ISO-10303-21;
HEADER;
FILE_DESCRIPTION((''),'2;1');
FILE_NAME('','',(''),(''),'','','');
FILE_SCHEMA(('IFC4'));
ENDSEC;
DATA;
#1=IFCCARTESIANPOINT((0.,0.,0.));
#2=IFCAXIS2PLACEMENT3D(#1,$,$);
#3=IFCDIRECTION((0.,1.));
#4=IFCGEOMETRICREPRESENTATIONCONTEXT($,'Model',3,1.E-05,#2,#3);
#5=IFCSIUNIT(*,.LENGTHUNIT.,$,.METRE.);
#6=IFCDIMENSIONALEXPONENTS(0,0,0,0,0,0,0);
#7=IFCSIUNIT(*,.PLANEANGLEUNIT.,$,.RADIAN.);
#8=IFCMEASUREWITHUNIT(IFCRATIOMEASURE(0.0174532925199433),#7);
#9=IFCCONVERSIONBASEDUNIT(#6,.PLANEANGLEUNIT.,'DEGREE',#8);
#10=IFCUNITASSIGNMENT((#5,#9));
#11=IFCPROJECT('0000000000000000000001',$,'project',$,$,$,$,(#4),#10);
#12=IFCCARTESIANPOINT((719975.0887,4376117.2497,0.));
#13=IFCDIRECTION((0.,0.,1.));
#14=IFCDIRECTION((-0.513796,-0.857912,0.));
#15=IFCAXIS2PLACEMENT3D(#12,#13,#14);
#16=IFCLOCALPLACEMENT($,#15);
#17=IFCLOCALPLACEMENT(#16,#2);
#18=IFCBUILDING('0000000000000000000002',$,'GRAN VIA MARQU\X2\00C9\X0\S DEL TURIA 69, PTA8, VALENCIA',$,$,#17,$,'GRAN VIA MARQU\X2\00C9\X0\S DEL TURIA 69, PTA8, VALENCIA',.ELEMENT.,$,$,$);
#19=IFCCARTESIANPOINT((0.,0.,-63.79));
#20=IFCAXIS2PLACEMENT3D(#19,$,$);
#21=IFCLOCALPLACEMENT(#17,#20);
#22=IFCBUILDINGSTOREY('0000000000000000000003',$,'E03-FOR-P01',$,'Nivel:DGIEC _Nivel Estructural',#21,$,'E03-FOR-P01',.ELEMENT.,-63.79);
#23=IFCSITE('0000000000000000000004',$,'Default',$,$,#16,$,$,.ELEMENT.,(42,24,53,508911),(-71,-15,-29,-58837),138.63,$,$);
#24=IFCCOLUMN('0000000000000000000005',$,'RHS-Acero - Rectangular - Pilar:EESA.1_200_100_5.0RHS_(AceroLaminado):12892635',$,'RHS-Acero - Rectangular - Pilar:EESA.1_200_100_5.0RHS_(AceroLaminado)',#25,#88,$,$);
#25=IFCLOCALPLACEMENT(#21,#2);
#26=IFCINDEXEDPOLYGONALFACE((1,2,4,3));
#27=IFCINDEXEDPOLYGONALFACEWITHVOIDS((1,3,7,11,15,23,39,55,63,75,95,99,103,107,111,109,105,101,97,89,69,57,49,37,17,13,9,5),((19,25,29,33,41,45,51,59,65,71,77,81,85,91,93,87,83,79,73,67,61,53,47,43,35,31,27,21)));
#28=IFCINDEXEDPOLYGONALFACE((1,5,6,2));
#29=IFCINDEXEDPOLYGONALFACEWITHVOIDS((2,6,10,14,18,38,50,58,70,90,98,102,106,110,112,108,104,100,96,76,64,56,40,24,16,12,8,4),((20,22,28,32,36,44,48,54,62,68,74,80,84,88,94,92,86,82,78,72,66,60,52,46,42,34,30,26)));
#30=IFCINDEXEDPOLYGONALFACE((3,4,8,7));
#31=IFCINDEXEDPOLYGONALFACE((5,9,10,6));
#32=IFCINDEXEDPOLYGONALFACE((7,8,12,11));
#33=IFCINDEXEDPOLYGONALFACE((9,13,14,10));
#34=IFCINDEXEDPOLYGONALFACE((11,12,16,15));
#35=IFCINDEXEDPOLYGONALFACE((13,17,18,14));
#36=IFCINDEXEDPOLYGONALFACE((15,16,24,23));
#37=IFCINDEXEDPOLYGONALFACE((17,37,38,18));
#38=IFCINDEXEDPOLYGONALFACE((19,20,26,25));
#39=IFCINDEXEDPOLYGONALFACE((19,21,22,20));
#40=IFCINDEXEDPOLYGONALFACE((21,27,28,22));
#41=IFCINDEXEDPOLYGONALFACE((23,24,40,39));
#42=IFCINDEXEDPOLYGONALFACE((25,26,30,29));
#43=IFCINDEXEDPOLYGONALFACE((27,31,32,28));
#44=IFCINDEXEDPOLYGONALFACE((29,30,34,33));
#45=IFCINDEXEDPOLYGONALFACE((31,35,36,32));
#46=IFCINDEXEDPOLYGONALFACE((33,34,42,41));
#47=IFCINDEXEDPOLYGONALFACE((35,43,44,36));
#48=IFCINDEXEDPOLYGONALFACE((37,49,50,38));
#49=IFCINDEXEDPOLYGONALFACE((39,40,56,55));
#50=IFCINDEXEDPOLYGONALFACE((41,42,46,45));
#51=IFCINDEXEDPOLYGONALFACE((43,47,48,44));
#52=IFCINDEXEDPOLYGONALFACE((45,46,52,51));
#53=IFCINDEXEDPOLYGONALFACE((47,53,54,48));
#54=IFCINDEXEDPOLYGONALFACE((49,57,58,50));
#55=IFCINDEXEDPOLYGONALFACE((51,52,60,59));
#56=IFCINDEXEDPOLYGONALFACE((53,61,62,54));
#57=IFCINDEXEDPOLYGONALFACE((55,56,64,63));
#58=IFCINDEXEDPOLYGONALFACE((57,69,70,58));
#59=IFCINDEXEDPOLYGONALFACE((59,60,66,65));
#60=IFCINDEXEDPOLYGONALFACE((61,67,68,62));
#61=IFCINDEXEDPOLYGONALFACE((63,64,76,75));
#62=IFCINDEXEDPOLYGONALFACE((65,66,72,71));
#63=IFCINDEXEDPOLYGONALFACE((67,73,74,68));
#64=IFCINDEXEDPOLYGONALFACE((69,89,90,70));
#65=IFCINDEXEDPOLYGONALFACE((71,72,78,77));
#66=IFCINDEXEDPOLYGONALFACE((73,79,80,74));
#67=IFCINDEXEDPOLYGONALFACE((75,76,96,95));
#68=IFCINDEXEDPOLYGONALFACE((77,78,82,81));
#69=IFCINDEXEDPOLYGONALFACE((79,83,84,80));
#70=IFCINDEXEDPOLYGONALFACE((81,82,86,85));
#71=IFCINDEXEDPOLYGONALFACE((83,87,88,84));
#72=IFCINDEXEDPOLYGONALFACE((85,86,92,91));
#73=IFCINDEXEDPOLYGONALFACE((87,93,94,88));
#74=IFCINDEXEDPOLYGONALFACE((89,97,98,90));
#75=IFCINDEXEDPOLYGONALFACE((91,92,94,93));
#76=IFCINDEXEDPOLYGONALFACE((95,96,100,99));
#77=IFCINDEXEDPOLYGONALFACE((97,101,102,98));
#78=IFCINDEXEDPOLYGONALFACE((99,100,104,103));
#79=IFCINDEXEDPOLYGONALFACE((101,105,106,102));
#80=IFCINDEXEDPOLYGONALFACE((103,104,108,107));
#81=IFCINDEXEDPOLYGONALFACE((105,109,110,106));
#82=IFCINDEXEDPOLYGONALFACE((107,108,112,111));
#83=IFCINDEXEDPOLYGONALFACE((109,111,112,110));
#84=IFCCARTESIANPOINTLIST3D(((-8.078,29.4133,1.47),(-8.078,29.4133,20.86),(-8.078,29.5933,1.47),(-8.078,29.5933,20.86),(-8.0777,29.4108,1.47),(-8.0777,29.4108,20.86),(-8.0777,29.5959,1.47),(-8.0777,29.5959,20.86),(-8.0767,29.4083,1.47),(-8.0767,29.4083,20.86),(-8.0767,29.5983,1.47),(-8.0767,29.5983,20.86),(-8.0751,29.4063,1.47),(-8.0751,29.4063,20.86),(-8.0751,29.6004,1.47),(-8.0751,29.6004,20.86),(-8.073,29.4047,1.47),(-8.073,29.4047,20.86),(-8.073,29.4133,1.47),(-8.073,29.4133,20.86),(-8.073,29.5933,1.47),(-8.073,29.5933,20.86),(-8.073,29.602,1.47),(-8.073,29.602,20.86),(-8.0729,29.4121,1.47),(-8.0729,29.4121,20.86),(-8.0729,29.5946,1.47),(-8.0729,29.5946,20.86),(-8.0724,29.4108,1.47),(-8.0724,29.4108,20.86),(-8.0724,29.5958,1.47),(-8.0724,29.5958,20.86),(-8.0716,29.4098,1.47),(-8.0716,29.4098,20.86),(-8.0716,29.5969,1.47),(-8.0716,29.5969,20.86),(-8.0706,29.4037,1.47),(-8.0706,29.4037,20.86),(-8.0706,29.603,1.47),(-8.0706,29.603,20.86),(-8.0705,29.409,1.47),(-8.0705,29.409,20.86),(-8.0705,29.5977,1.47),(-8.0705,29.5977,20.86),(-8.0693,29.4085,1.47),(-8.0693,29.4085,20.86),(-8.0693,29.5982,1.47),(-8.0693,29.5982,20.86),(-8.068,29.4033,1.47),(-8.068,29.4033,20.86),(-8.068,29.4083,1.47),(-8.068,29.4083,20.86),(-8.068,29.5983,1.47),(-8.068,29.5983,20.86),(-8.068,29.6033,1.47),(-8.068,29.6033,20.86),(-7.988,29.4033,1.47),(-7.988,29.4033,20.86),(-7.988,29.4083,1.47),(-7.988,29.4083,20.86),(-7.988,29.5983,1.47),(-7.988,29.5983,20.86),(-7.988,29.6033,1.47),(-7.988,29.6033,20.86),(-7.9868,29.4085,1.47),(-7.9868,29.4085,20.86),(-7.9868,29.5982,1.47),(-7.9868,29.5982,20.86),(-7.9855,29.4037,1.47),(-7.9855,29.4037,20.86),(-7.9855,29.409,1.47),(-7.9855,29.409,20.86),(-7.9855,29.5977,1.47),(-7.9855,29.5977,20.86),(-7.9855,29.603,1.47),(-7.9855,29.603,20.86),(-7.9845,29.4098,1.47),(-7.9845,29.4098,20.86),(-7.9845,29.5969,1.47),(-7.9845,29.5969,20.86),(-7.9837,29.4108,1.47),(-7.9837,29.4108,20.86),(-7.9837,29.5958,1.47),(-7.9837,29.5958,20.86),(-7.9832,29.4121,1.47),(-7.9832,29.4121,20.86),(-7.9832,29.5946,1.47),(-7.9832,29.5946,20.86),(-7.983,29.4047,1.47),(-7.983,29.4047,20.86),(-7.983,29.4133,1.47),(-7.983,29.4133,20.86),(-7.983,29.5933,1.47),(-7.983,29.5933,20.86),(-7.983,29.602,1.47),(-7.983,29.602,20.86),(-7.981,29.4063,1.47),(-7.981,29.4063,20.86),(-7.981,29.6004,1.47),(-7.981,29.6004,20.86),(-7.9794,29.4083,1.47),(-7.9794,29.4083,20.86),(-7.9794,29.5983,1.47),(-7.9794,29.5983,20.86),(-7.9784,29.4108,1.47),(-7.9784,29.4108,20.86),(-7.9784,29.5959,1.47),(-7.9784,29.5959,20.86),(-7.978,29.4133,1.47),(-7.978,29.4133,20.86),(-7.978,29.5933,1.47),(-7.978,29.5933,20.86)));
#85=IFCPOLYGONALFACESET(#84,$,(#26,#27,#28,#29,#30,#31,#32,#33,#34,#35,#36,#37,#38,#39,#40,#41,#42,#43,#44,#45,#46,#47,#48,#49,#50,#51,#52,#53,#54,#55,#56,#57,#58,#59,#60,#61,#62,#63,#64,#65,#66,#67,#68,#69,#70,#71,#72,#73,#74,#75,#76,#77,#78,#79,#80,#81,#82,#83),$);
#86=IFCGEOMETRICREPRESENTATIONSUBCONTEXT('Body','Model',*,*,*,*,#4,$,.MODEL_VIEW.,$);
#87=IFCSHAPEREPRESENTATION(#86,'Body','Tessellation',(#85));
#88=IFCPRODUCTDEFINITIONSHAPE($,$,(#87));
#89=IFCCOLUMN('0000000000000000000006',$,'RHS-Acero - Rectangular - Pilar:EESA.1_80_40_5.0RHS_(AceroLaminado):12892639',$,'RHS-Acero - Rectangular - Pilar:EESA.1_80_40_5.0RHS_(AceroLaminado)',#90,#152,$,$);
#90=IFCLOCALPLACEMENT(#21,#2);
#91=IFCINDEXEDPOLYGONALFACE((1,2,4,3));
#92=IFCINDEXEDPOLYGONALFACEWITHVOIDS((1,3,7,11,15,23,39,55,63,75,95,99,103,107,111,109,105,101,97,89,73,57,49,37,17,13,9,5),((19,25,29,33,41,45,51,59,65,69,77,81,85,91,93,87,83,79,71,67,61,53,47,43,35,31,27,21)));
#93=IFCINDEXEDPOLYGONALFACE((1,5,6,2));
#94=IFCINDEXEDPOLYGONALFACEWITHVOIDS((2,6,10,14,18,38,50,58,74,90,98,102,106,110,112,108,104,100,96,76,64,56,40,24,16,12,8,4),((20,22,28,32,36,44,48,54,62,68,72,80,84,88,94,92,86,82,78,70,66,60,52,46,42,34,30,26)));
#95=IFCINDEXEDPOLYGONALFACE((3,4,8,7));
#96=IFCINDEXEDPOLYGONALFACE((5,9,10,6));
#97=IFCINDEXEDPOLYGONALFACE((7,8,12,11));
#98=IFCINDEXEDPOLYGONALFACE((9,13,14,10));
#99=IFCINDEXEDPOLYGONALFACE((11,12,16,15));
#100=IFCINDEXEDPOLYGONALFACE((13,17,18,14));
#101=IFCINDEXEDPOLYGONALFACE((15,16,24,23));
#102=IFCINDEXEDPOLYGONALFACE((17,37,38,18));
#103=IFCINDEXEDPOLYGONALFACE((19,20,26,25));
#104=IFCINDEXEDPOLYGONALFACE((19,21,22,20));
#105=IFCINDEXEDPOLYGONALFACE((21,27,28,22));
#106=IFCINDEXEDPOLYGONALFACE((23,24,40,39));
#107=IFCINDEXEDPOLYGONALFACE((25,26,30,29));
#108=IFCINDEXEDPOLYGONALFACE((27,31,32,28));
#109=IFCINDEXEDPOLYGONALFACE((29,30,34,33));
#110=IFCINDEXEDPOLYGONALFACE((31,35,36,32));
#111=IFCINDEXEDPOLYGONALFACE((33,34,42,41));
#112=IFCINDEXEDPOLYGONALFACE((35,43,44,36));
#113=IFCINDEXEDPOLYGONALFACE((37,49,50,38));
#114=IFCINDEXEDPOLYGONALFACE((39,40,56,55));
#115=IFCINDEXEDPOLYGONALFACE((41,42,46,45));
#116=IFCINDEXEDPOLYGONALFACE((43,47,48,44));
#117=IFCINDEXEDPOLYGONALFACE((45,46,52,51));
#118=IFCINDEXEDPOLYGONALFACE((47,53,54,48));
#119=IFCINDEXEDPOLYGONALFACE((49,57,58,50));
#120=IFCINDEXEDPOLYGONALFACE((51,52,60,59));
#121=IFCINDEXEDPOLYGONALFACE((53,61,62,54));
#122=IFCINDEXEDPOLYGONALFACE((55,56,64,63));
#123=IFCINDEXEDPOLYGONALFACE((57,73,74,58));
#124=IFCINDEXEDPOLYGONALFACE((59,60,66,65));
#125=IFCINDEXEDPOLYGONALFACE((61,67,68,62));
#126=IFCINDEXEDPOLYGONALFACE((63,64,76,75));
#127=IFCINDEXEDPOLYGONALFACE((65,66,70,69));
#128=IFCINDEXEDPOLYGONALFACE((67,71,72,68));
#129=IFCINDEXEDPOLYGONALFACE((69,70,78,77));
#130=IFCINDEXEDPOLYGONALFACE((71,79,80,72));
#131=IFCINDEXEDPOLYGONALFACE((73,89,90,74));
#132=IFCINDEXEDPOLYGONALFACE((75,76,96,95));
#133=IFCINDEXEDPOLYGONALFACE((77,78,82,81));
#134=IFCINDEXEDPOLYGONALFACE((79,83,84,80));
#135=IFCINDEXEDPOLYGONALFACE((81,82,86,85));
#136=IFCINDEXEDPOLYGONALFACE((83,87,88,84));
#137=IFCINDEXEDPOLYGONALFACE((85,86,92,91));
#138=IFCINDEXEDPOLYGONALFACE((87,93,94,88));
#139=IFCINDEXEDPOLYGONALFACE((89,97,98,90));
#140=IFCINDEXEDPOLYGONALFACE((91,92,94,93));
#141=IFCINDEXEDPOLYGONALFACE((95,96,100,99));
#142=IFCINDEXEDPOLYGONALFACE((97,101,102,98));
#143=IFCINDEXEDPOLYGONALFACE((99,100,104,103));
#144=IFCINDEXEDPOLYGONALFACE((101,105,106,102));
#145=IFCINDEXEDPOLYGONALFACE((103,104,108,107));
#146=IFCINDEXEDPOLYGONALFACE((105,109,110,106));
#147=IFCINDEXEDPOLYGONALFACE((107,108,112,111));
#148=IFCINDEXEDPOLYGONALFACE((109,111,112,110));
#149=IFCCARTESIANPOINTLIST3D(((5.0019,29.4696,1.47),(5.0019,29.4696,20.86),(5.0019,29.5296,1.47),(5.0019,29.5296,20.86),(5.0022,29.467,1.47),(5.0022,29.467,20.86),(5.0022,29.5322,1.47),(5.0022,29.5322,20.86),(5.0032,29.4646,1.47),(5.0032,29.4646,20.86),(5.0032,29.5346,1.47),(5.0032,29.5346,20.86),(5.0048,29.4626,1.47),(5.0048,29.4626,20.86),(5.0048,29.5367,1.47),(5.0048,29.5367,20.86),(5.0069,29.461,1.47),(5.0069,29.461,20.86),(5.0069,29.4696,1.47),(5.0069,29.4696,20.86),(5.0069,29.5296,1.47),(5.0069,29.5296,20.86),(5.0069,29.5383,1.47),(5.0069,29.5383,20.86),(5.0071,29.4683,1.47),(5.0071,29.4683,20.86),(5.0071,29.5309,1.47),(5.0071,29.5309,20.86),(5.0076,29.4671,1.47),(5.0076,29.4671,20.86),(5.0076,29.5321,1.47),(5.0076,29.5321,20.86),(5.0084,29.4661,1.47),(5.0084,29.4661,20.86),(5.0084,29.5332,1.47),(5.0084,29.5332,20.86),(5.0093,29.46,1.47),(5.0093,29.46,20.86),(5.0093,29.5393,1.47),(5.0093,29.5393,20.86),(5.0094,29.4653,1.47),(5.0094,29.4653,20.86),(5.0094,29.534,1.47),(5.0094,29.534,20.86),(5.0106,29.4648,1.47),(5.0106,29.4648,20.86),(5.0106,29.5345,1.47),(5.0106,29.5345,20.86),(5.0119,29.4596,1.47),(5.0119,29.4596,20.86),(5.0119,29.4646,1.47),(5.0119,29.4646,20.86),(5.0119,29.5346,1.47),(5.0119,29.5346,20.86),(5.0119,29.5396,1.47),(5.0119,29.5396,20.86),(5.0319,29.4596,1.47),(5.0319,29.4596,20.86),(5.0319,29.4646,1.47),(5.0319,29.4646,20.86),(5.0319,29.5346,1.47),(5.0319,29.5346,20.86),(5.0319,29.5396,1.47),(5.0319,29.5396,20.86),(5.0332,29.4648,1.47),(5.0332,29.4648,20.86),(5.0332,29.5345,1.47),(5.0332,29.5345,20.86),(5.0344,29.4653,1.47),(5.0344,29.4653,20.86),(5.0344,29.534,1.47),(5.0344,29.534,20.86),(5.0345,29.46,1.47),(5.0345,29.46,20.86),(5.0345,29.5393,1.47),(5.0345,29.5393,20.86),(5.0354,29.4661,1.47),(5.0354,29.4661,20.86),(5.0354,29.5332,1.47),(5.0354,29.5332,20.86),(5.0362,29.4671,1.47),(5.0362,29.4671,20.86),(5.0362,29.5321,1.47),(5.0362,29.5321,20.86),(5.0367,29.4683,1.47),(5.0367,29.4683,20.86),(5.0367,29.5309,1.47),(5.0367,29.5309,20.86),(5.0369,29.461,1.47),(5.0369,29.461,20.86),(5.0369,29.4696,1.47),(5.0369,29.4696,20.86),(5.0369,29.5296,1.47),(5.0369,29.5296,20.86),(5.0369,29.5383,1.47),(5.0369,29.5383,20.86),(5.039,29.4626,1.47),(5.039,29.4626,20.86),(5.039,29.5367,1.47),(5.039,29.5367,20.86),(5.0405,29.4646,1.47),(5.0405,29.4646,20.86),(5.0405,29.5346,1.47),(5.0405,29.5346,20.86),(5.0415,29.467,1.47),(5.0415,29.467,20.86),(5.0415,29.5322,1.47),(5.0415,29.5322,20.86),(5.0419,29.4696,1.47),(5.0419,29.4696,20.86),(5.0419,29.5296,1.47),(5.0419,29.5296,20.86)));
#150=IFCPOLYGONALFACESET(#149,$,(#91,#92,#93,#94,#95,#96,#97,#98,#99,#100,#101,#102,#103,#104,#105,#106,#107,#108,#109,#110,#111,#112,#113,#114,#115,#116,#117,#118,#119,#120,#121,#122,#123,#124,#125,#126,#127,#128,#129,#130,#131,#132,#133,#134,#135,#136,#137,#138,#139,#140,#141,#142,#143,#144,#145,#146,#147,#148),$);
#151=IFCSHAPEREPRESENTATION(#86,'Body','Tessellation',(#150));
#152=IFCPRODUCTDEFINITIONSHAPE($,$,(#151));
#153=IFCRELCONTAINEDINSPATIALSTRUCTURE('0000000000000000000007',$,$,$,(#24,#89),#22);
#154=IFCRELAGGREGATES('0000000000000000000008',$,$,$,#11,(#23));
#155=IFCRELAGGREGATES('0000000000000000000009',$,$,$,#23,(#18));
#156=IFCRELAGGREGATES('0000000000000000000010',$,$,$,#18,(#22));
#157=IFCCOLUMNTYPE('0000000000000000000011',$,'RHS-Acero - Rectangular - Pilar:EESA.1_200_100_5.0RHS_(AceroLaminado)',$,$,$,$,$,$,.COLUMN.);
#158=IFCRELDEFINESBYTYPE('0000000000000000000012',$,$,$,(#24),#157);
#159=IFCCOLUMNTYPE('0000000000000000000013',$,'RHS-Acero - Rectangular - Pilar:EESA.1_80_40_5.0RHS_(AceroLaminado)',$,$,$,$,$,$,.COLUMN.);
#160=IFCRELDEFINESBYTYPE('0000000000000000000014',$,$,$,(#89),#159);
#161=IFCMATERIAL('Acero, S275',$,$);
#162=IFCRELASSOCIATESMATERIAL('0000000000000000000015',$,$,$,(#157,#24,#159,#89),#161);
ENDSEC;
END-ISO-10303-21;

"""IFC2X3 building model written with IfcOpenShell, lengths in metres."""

from ifc_helpers import new_model, entity, si_unit, converted_unit, direction, frame, frame_2d, origin, place, context, subcontext, project, spatial, polyline, circle_curve, parameter, trimmed, segment, composite_curve, outline, extrude, source, transform, mapped, material, type_object, type_shapes, element, save


model = new_model("IFC2X3")

# Units and contexts
model_context = context("Model", 3, precision=1e-05, world=origin(), true_north=direction((0.0, 1.0)))
body_context = subcontext(model_context, "Body", "Model", "MODEL_VIEW")
ifc_project = project(units=[si_unit("LENGTHUNIT", "METRE"), converted_unit("PLANEANGLEUNIT", "DEGREE", entity("IfcRatioMeasure", 0.0174532925199433), si_unit("PLANEANGLEUNIT", "RADIAN"), dimensions=[0, 0, 0, 0, 0, 0, 0])], contexts=[model_context])

# Site, building, storey
site_placement = place(None, frame((719975.0887, 4376117.2497, 0.0), z_axis=(0.0, 0.0, 1.0), x_axis=(-0.513796, -0.857912, 0.0)))
site = spatial("IfcSite", under=ifc_project, at=site_placement, Name="Default", CompositionType="ELEMENT", RefLatitude=(42, 24, 53, 508911), RefLongitude=(-71, -15, -29, -58837), RefElevation=138.63)
building_placement = place(site_placement, origin())
building = spatial("IfcBuilding", under=site, at=building_placement, Name="GRAN VIA MARQUÉS DEL TURIA 69, PTA8, VALENCIA", LongName="GRAN VIA MARQUÉS DEL TURIA 69, PTA8, VALENCIA", CompositionType="ELEMENT")
storey_placement = place(building_placement, frame((0.0, 0.0, -63.79)))
storey = spatial("IfcBuildingStorey", under=building, at=storey_placement, Name="E03-FOR-P01", ObjectType="Nivel:DGIEC _Nivel Estructural", LongName="E03-FOR-P01", CompositionType="ELEMENT", Elevation=-63.79)

# Columns
ifc_material_1 = material(Name="Acero, S275")
column_type_1 = type_object("IfcColumnType", Name="RHS-Acero - Rectangular - Pilar:EESA.1_200_100_5.0RHS_(AceroLaminado)", PredefinedType="COLUMN", material=ifc_material_1)
shared_shape_1 = source(origin(), body_context, "Body", "SweptSolid", [
    extrude(outline(composite_curve([segment(polyline([(-0.04, -0.1), (0.04, -0.1)]), True, "CONTINUOUS"), segment(trimmed(circle_curve(frame_2d((0.04, -0.09), x_axis=(-1.0, 0.0)), 0.01), [parameter(90.0)], [parameter(180.0)], True, "PARAMETER"), True, "CONTINUOUS"), segment(polyline([(0.05, -0.09), (0.05, 0.09)]), True, "CONTINUOUS"), segment(trimmed(circle_curve(frame_2d((0.04, 0.09), x_axis=(-1.0, 0.0)), 0.01), [parameter(180.0)], [parameter(270.0)], True, "PARAMETER"), True, "CONTINUOUS"), segment(polyline([(0.04, 0.1), (-0.04, 0.1)]), True, "CONTINUOUS"), segment(trimmed(circle_curve(frame_2d((-0.04, 0.09), x_axis=(-1.0, 0.0)), 0.01), [parameter(270.0)], [parameter(360.0)], True, "PARAMETER"), True, "CONTINUOUS"), segment(polyline([(-0.05, 0.09), (-0.05, -0.09)]), True, "CONTINUOUS"), segment(trimmed(circle_curve(frame_2d((-0.04, -0.09), x_axis=(-1.0, 0.0)), 0.01), [parameter(360.0)], [parameter(90.0)], True, "PARAMETER"), True, "CONTINUOUS")], self_intersect=False), holes=[composite_curve([segment(trimmed(circle_curve(frame_2d((-0.04, -0.09), x_axis=(-1.0, 0.0)), 0.005), [parameter(0.0)], [parameter(90.0)], True, "PARAMETER"), False, "CONTINUOUS"), segment(polyline([(-0.045, -0.09), (-0.045, 0.09)]), True, "CONTINUOUS"), segment(trimmed(circle_curve(frame_2d((-0.04, 0.09), x_axis=(-1.0, 0.0)), 0.005), [parameter(270.0)], [parameter(0.0)], True, "PARAMETER"), False, "CONTINUOUS"), segment(polyline([(-0.04, 0.095), (0.04, 0.095)]), True, "CONTINUOUS"), segment(trimmed(circle_curve(frame_2d((0.04, 0.09), x_axis=(-1.0, 0.0)), 0.005), [parameter(180.0)], [parameter(270.0)], True, "PARAMETER"), False, "CONTINUOUS"), segment(polyline([(0.045, 0.09), (0.045, -0.09)]), True, "CONTINUOUS"), segment(trimmed(circle_curve(frame_2d((0.04, -0.09), x_axis=(-1.0, 0.0)), 0.005), [parameter(90.0)], [parameter(180.0)], True, "PARAMETER"), False, "CONTINUOUS"), segment(polyline([(0.04, -0.095), (-0.04, -0.095)]), True, "CONTINUOUS")], self_intersect=False)]), frame((0.0, 0.0, -62.32), z_axis=(0.0, 0.0, 1.0), x_axis=(-1.0, 0.0, 0.0)), (0.0, 0.0, 1.0), 19.39),
])
type_shapes(column_type_1, [shared_shape_1])
for number, where, z_axis, x_axis, name in (
    (1, (-8.028, 29.5033, 63.79), (0.0, 0.0, 1.0), (-1.0, 0.0, 0.0), "RHS-Acero - Rectangular - Pilar:EESA.1_200_100_5.0RHS_(AceroLaminado):12892635"),
):
    element("IfcColumn", number, at=place(storey_placement, frame(where, z_axis=z_axis, x_axis=x_axis)), inside=storey, type_object=column_type_1, material=ifc_material_1, Name=name, ObjectType="RHS-Acero - Rectangular - Pilar:EESA.1_200_100_5.0RHS_(AceroLaminado)", context=body_context, shape_type="MappedRepresentation", body=[
        mapped(shared_shape_1, transform((0.0, 0.0, 0.0), scale=1.0)),
    ])
column_type_2 = type_object("IfcColumnType", Name="RHS-Acero - Rectangular - Pilar:EESA.1_80_40_5.0RHS_(AceroLaminado)", PredefinedType="COLUMN", material=ifc_material_1)
shared_shape_2 = source(origin(), body_context, "Body", "SweptSolid", [
    extrude(outline(composite_curve([segment(polyline([(-0.01, -0.04), (0.01, -0.04)]), True, "CONTINUOUS"), segment(trimmed(circle_curve(frame_2d((0.01, -0.03), x_axis=(-1.0, 0.0)), 0.01), [parameter(90.0)], [parameter(180.0)], True, "PARAMETER"), True, "CONTINUOUS"), segment(polyline([(0.02, -0.03), (0.02, 0.03)]), True, "CONTINUOUS"), segment(trimmed(circle_curve(frame_2d((0.01, 0.03), x_axis=(-1.0, 0.0)), 0.01), [parameter(180.0)], [parameter(270.0)], True, "PARAMETER"), True, "CONTINUOUS"), segment(polyline([(0.01, 0.04), (-0.01, 0.04)]), True, "CONTINUOUS"), segment(trimmed(circle_curve(frame_2d((-0.01, 0.03), x_axis=(-1.0, 0.0)), 0.01), [parameter(270.0)], [parameter(360.0)], True, "PARAMETER"), True, "CONTINUOUS"), segment(polyline([(-0.02, 0.03), (-0.02, -0.03)]), True, "CONTINUOUS"), segment(trimmed(circle_curve(frame_2d((-0.01, -0.03), x_axis=(-1.0, 0.0)), 0.01), [parameter(360.0)], [parameter(90.0)], True, "PARAMETER"), True, "CONTINUOUS")], self_intersect=False), holes=[composite_curve([segment(trimmed(circle_curve(frame_2d((-0.01, -0.03), x_axis=(-1.0, 0.0)), 0.005), [parameter(0.0)], [parameter(90.0)], True, "PARAMETER"), False, "CONTINUOUS"), segment(polyline([(-0.015, -0.03), (-0.015, 0.03)]), True, "CONTINUOUS"), segment(trimmed(circle_curve(frame_2d((-0.01, 0.03), x_axis=(-1.0, 0.0)), 0.005), [parameter(270.0)], [parameter(0.0)], True, "PARAMETER"), False, "CONTINUOUS"), segment(polyline([(-0.01, 0.035), (0.01, 0.035)]), True, "CONTINUOUS"), segment(trimmed(circle_curve(frame_2d((0.01, 0.03), x_axis=(-1.0, 0.0)), 0.005), [parameter(180.0)], [parameter(270.0)], True, "PARAMETER"), False, "CONTINUOUS"), segment(polyline([(0.015, 0.03), (0.015, -0.03)]), True, "CONTINUOUS"), segment(trimmed(circle_curve(frame_2d((0.01, -0.03), x_axis=(-1.0, 0.0)), 0.005), [parameter(90.0)], [parameter(180.0)], True, "PARAMETER"), False, "CONTINUOUS"), segment(polyline([(0.01, -0.035), (-0.01, -0.035)]), True, "CONTINUOUS")], self_intersect=False)]), frame((0.0, 0.0, -62.32), z_axis=(0.0, 0.0, 1.0), x_axis=(-1.0, 0.0, 0.0)), (0.0, 0.0, 1.0), 19.39),
])
type_shapes(column_type_2, [shared_shape_2])
for number, where, z_axis, x_axis, name in (
    (2, (5.0219, 29.4996, 63.79), (0.0, 0.0, 1.0), (-1.0, 0.0, 0.0), "RHS-Acero - Rectangular - Pilar:EESA.1_80_40_5.0RHS_(AceroLaminado):12892639"),
):
    element("IfcColumn", number, at=place(storey_placement, frame(where, z_axis=z_axis, x_axis=x_axis)), inside=storey, type_object=column_type_2, material=ifc_material_1, Name=name, ObjectType="RHS-Acero - Rectangular - Pilar:EESA.1_80_40_5.0RHS_(AceroLaminado)", context=body_context, shape_type="MappedRepresentation", body=[
        mapped(shared_shape_2, transform((0.0, 0.0, 0.0), scale=1.0)),
    ])

save(model, "model.ifc")
